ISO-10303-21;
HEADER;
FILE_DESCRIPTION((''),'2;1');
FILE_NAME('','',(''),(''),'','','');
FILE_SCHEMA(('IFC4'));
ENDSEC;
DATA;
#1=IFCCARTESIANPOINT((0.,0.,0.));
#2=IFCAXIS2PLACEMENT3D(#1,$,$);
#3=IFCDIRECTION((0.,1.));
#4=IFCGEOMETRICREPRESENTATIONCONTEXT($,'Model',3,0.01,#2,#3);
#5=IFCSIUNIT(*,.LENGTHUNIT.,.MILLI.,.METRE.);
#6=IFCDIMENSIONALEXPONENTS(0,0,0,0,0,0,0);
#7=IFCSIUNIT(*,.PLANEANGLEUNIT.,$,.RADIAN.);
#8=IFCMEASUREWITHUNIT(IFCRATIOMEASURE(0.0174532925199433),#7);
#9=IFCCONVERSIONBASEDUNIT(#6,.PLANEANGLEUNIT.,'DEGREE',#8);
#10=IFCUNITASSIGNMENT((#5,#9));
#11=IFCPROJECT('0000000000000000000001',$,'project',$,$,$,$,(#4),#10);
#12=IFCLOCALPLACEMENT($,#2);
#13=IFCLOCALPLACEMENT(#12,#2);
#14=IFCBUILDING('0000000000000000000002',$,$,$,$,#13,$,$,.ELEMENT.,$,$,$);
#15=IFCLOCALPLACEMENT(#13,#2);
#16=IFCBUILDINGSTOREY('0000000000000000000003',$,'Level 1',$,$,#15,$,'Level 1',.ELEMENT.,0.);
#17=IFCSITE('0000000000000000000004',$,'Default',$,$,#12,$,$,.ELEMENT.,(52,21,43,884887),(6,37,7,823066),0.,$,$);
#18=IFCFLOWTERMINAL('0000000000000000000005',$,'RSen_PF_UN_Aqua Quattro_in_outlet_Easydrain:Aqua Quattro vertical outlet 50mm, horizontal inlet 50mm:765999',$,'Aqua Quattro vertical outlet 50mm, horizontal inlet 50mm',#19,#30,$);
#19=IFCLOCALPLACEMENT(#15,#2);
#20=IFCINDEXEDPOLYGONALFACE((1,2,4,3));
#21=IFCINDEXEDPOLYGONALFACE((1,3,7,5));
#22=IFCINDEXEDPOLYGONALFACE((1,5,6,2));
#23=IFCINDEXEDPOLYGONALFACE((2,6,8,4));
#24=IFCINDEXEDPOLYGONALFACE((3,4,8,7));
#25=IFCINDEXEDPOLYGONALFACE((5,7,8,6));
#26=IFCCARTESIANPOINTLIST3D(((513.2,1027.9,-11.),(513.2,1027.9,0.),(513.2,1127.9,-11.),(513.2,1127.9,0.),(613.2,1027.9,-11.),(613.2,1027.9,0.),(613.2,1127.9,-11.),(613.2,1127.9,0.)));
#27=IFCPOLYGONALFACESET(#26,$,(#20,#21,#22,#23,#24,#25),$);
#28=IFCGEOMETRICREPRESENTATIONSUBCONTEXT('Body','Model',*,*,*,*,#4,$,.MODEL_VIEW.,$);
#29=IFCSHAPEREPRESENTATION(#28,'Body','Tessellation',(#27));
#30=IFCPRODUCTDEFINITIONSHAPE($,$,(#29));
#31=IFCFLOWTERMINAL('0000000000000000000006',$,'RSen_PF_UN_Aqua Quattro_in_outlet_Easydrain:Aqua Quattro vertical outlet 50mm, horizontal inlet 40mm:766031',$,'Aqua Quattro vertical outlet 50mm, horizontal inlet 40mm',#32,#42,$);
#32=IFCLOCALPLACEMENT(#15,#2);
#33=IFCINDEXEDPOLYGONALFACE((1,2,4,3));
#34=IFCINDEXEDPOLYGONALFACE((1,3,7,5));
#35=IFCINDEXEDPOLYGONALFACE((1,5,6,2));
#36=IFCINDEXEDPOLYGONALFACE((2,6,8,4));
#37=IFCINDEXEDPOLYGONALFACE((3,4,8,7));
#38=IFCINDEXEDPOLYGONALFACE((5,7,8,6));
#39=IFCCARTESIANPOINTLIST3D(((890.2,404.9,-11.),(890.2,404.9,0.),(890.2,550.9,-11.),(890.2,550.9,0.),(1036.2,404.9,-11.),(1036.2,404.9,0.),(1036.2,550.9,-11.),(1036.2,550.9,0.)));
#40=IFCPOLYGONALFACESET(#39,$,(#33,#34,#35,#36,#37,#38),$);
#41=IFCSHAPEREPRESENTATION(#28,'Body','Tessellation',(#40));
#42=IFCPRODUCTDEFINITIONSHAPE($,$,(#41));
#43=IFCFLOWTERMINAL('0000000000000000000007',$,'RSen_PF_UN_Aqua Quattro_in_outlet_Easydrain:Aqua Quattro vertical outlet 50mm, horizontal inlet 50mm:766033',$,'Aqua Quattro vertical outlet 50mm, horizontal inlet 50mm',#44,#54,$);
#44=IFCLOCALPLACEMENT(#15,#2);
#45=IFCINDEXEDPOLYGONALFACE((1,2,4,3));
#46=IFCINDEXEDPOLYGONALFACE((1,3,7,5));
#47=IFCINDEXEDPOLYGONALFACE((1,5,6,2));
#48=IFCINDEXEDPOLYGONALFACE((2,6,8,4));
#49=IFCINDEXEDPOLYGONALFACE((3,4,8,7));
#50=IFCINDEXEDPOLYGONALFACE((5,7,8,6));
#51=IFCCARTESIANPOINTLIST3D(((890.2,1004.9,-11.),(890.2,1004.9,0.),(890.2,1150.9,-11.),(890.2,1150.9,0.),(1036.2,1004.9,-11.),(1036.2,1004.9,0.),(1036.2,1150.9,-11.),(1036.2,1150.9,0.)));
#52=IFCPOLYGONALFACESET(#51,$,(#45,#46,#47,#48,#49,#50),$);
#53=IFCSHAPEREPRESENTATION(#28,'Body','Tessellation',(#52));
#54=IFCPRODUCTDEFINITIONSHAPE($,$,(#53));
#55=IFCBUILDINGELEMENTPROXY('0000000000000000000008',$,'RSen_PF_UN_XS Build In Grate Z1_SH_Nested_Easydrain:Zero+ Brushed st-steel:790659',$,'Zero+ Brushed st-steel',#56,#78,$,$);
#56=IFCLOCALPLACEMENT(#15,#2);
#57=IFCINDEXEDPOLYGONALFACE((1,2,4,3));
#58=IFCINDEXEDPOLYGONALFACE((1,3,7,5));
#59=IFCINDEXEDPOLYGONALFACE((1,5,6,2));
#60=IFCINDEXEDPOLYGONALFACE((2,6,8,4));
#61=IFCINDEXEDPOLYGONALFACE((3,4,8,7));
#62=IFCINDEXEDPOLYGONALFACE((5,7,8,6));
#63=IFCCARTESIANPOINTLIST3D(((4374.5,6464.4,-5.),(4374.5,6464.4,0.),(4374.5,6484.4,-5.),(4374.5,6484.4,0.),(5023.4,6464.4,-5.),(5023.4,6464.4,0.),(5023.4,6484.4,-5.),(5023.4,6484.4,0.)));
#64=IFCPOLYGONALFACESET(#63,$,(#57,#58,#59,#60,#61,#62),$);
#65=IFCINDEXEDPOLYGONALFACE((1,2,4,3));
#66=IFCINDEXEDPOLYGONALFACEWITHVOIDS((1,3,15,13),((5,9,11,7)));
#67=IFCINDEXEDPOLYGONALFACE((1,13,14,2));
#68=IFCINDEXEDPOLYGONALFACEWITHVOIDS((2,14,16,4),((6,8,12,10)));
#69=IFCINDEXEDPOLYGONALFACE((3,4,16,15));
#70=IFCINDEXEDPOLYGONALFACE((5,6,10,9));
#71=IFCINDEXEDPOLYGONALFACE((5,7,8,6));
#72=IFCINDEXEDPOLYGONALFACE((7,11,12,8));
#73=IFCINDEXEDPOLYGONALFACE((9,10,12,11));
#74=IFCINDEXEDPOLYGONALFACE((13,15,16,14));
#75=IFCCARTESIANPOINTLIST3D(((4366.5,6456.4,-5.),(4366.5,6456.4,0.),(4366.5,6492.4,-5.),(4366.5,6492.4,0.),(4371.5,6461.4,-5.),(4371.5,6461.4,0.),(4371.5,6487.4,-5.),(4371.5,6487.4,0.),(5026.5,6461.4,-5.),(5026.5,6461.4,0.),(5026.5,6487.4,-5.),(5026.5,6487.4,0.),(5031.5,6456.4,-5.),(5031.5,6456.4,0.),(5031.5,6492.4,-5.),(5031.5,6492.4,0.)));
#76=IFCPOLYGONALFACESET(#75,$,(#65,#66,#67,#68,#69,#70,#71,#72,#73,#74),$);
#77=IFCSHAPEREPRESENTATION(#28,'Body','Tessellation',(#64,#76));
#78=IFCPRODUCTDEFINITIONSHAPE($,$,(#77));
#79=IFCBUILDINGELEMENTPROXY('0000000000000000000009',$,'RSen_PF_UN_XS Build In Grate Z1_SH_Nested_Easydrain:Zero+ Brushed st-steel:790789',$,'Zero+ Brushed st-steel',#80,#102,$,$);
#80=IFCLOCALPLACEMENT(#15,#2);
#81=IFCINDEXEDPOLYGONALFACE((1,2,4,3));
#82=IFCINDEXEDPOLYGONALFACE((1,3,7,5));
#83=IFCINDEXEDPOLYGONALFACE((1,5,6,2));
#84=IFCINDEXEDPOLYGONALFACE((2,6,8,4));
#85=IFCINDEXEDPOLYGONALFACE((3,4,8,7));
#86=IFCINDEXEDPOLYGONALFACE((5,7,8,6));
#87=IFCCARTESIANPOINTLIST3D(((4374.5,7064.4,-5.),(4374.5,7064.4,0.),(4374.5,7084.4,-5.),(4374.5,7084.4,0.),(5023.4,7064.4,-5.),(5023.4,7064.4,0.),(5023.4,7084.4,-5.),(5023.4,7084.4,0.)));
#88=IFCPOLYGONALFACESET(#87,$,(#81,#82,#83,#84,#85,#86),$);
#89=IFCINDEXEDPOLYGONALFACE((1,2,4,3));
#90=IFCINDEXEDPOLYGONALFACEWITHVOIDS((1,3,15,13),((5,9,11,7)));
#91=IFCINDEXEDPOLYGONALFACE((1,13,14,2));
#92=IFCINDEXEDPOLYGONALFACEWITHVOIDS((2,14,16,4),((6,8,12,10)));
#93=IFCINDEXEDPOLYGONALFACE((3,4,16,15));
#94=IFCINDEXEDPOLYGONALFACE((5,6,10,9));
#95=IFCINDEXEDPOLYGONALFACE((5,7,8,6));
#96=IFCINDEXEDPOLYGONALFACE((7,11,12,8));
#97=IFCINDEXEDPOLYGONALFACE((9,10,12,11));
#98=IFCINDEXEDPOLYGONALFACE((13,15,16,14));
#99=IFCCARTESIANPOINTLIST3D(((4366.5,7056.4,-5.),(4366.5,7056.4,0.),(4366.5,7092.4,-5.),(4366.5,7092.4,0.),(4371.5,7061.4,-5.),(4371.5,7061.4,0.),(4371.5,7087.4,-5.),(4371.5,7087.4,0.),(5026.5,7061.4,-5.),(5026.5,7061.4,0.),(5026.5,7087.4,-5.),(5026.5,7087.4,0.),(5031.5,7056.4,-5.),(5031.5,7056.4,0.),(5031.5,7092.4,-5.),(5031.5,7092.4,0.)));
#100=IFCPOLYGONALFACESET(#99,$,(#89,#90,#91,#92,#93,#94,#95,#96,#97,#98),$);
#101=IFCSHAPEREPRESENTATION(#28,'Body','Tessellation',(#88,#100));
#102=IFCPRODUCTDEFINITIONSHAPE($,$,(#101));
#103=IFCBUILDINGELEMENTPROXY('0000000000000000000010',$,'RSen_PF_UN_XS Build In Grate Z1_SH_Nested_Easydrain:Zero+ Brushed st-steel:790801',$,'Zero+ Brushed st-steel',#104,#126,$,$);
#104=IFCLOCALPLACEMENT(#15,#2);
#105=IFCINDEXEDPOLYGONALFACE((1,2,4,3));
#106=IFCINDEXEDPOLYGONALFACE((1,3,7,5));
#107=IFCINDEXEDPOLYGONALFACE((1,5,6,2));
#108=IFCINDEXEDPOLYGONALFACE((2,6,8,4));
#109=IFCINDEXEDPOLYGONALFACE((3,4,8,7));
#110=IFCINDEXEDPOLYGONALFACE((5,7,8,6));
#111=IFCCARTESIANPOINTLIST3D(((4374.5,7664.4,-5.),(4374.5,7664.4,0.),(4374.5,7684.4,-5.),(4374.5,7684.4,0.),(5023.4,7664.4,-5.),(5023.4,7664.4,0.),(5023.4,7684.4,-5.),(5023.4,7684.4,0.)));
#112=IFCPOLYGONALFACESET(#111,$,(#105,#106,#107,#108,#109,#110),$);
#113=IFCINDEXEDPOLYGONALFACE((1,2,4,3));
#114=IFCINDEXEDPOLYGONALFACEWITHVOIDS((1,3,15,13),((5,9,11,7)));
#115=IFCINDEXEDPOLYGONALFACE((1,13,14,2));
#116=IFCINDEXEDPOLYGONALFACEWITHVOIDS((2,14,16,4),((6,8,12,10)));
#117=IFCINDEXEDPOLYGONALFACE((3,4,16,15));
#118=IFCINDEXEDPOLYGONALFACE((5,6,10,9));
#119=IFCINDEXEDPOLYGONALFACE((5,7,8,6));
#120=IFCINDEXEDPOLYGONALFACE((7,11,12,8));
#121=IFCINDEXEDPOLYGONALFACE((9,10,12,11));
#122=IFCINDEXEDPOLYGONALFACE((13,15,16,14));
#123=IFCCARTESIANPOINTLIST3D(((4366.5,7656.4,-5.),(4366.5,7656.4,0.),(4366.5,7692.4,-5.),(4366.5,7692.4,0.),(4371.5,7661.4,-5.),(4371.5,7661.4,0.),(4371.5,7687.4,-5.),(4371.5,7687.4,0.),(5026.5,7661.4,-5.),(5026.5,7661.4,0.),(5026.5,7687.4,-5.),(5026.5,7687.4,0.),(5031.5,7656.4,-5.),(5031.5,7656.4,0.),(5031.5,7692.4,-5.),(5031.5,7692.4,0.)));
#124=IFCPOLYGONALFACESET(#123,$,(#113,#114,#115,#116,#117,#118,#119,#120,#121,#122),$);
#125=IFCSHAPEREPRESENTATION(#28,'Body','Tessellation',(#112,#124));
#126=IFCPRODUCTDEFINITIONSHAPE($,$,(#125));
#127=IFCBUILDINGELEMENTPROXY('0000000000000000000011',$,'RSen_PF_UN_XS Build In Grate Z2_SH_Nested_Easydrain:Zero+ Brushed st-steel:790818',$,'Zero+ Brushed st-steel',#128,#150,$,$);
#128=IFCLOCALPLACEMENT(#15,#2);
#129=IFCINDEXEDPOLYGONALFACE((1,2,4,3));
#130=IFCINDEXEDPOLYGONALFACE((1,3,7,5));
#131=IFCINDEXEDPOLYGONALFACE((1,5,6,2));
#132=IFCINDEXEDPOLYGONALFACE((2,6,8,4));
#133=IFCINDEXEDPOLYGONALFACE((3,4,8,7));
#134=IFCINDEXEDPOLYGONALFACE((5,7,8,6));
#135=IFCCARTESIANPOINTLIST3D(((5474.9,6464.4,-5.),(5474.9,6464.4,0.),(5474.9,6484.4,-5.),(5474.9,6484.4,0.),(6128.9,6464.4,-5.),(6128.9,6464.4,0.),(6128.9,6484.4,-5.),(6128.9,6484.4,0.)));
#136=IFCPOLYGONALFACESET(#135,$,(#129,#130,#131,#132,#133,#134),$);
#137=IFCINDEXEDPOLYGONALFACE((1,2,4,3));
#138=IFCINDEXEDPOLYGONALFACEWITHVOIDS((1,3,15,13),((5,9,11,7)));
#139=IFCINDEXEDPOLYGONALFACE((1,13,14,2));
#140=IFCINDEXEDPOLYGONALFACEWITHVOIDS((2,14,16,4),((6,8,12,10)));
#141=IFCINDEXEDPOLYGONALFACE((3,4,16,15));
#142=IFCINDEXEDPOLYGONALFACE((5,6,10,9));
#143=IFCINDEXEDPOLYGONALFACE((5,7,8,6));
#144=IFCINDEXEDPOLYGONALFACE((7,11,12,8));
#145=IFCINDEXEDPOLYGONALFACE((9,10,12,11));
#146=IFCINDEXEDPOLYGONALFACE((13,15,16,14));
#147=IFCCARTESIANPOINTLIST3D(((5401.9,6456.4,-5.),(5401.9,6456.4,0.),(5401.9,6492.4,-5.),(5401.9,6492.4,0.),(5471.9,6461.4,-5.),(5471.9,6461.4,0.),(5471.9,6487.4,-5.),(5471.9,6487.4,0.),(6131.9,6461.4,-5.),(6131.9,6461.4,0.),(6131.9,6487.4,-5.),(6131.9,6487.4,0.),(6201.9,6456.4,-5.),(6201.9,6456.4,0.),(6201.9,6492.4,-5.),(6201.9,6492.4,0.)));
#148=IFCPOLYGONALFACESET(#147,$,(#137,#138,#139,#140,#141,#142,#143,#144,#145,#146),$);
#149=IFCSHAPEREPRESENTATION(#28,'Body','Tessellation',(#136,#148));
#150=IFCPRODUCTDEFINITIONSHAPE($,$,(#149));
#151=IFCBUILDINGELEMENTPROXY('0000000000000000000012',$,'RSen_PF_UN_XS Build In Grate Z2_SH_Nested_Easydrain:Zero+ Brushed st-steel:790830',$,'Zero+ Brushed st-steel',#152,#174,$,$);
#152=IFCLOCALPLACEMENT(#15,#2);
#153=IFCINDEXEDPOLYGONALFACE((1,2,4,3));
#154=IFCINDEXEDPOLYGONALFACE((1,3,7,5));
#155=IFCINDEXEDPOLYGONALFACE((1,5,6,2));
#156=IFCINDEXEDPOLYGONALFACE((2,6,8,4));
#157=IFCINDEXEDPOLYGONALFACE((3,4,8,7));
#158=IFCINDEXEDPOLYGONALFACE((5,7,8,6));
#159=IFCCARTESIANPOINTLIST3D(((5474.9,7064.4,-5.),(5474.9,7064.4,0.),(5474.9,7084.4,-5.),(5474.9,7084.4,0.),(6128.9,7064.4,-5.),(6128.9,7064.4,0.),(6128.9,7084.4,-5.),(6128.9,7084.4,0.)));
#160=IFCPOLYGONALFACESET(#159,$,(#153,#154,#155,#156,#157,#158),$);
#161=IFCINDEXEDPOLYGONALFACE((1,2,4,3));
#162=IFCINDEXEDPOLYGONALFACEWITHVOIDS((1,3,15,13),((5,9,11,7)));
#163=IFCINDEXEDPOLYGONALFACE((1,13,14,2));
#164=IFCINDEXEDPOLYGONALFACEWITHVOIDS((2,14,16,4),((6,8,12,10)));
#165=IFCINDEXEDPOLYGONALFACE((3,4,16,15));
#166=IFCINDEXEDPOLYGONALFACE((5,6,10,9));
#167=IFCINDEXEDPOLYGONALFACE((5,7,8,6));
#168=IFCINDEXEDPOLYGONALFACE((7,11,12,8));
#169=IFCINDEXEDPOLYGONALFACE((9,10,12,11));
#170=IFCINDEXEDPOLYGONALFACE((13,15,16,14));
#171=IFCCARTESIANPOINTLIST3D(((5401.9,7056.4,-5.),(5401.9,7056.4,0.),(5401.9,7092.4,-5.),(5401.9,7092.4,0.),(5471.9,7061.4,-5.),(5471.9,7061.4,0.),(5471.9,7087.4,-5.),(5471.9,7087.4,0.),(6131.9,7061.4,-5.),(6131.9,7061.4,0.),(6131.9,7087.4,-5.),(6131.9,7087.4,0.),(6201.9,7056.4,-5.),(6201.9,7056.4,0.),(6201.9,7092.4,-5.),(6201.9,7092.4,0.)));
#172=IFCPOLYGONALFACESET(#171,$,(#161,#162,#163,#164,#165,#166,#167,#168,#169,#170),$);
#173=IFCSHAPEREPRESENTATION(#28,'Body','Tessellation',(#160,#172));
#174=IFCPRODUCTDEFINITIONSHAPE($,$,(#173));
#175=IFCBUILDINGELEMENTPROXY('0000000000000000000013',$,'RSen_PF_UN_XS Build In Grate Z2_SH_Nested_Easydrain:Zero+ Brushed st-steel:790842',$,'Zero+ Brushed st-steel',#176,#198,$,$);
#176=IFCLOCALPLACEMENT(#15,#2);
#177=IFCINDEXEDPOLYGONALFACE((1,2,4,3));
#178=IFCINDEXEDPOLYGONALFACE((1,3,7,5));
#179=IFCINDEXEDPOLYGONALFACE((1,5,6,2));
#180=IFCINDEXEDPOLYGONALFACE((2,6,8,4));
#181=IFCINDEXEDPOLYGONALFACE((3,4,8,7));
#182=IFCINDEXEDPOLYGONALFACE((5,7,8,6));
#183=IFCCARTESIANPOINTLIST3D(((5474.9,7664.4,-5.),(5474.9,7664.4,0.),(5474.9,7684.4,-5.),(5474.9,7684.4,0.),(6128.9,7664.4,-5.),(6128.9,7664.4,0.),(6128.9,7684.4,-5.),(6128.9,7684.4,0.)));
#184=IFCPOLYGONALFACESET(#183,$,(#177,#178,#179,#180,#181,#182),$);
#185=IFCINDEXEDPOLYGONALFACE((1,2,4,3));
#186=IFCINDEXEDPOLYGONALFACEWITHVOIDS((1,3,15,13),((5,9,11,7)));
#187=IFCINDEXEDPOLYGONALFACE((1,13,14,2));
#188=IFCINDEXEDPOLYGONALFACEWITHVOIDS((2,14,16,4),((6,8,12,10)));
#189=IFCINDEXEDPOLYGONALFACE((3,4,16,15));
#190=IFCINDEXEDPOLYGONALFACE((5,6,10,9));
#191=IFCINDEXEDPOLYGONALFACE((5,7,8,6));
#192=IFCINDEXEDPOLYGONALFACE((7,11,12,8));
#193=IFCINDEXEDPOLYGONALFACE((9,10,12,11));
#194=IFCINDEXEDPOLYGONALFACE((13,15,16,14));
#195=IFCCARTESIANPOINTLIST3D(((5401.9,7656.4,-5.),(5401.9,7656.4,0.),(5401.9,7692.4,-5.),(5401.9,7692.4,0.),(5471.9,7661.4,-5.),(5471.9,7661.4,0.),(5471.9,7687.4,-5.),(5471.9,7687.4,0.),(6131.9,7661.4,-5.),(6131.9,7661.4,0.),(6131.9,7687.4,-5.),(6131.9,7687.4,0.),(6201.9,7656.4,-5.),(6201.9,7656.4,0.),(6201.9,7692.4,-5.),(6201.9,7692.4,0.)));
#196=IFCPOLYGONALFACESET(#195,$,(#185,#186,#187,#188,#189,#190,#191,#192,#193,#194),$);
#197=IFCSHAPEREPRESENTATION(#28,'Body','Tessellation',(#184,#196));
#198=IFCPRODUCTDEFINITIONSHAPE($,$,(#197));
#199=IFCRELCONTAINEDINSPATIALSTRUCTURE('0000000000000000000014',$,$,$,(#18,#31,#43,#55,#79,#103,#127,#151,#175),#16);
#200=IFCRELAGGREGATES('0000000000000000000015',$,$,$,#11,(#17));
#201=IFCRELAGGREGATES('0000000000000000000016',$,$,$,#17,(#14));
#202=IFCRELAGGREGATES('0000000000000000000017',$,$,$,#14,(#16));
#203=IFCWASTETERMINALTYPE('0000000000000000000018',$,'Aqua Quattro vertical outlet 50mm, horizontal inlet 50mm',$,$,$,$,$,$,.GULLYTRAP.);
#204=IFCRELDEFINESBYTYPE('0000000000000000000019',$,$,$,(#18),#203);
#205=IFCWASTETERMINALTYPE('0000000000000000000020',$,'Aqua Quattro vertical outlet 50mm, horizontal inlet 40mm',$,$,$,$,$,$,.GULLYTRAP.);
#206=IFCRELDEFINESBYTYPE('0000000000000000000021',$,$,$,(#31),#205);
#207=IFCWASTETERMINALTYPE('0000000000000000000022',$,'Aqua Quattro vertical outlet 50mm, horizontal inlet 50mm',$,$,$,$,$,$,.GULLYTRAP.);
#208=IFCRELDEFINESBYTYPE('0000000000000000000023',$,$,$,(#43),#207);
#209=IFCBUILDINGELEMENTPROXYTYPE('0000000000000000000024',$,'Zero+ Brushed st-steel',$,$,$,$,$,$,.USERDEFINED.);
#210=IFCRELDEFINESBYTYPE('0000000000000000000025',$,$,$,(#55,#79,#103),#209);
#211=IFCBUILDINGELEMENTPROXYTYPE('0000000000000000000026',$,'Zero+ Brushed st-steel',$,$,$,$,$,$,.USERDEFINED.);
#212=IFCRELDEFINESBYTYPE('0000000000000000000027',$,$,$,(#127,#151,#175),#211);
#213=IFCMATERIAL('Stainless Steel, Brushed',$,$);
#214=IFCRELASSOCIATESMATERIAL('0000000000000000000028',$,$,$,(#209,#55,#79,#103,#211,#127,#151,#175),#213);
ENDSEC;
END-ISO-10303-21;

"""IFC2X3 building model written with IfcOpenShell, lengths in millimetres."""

from ifc_helpers import new_model, entity, si_unit, converted_unit, direction, frame, origin, origin_2d_with_axis, place, context, subcontext, project, spatial, polyline, rectangle, outline, extrude, source, transform, mapped, material, type_object, type_shapes, element, save


model = new_model("IFC2X3")

# Units and contexts
model_context = context("Model", 3, precision=0.01, world=origin(), true_north=direction((0.0, 1.0)))
body_context = subcontext(model_context, "Body", "Model", "MODEL_VIEW")
ifc_project = project(units=[si_unit("LENGTHUNIT", "METRE", prefix="MILLI"), converted_unit("PLANEANGLEUNIT", "DEGREE", entity("IfcRatioMeasure", 0.0174532925199433), si_unit("PLANEANGLEUNIT", "RADIAN"), dimensions=[0, 0, 0, 0, 0, 0, 0])], contexts=[model_context])

# Site, building, storey
site_placement = place(None, origin())
site = spatial("IfcSite", under=ifc_project, at=site_placement, Name="Default", CompositionType="ELEMENT", RefLatitude=(52, 21, 43, 884887), RefLongitude=(6, 37, 7, 823066), RefElevation=0.0)
building_placement = place(site_placement, origin())
building = spatial("IfcBuilding", under=site, at=building_placement, CompositionType="ELEMENT")
storey_placement = place(building_placement, origin())
storey = spatial("IfcBuildingStorey", under=building, at=storey_placement, Name="Level 1", LongName="Level 1", CompositionType="ELEMENT", Elevation=0.0)

# Flow terminals
waste_terminal_type_1 = type_object("IfcWasteTerminalType", Name="Aqua Quattro vertical outlet 50mm, horizontal inlet 50mm", PredefinedType="GULLYTRAP")
shared_shape_1 = source(origin(), body_context, "Body", "SweptSolid", [
    extrude(rectangle(XDim=100.0, YDim=100.0, at=origin_2d_with_axis()), frame((0.0, 0.0, -11.0), z_axis=(0.0, 0.0, 1.0), x_axis=(-1.0, 0.0, 0.0)), (0.0, 0.0, 1.0), 11.0),
])
type_shapes(waste_terminal_type_1, [shared_shape_1])
flow_terminal_1_placement = place(storey_placement, frame((563.2, 1077.9, 0.0)))
element("IfcFlowTerminal", 1, at=flow_terminal_1_placement, inside=storey, type_object=waste_terminal_type_1, Name="RSen_PF_UN_Aqua Quattro_in_outlet_Easydrain:Aqua Quattro vertical outlet 50mm, horizontal inlet 50mm:765999", ObjectType="Aqua Quattro vertical outlet 50mm, horizontal inlet 50mm", context=body_context, shape_type="MappedRepresentation", body=[
    mapped(shared_shape_1, transform((0.0, 0.0, 0.0), scale=1.0)),
])
waste_terminal_type_2 = type_object("IfcWasteTerminalType", Name="Aqua Quattro vertical outlet 50mm, horizontal inlet 40mm", PredefinedType="GULLYTRAP")
shared_shape_2 = source(origin(), body_context, "Body", "SweptSolid", [
    extrude(rectangle(XDim=146.0, YDim=146.0, at=origin_2d_with_axis()), frame((0.0, 0.0, -11.0), z_axis=(0.0, 0.0, 1.0), x_axis=(-1.0, 0.0, 0.0)), (0.0, 0.0, 1.0), 11.0),
])
type_shapes(waste_terminal_type_2, [shared_shape_2])
flow_terminal_2_placement = place(storey_placement, frame((963.2, 477.9, 0.0)))
element("IfcFlowTerminal", 2, at=flow_terminal_2_placement, inside=storey, type_object=waste_terminal_type_2, Name="RSen_PF_UN_Aqua Quattro_in_outlet_Easydrain:Aqua Quattro vertical outlet 50mm, horizontal inlet 40mm:766031", ObjectType="Aqua Quattro vertical outlet 50mm, horizontal inlet 40mm", context=body_context, shape_type="MappedRepresentation", body=[
    mapped(shared_shape_2, transform((0.0, 0.0, 0.0), scale=1.0)),
])
waste_terminal_type_3 = type_object("IfcWasteTerminalType", Name="Aqua Quattro vertical outlet 50mm, horizontal inlet 50mm", PredefinedType="GULLYTRAP")
shared_shape_3 = source(origin(), body_context, "Body", "SweptSolid", [
    extrude(rectangle(XDim=146.0, YDim=146.0, at=origin_2d_with_axis()), frame((0.0, 0.0, -11.0), z_axis=(0.0, 0.0, 1.0), x_axis=(-1.0, 0.0, 0.0)), (0.0, 0.0, 1.0), 11.0),
])
type_shapes(waste_terminal_type_3, [shared_shape_3])
flow_terminal_3_placement = place(storey_placement, frame((963.2, 1077.9, 0.0)))
element("IfcFlowTerminal", 3, at=flow_terminal_3_placement, inside=storey, type_object=waste_terminal_type_3, Name="RSen_PF_UN_Aqua Quattro_in_outlet_Easydrain:Aqua Quattro vertical outlet 50mm, horizontal inlet 50mm:766033", ObjectType="Aqua Quattro vertical outlet 50mm, horizontal inlet 50mm", context=body_context, shape_type="MappedRepresentation", body=[
    mapped(shared_shape_3, transform((0.0, 0.0, 0.0), scale=1.0)),
])

# Building element proxies
ifc_material_1 = material(Name="Stainless Steel, Brushed")
building_element_proxy_type_1 = type_object("IfcBuildingElementProxyType", Name="Zero+ Brushed st-steel", PredefinedType="USERDEFINED", material=ifc_material_1)
shared_shape_4 = source(origin(), body_context, "Body", "SweptSolid", [
    extrude(rectangle(XDim=649.0, YDim=20.0, at=origin_2d_with_axis()), frame((0.0, 0.0, 0.0), z_axis=(0.0, 0.0, 1.0), x_axis=(-1.0, 0.0, 0.0)), (0.0, 0.0, 1.0), 5.0),
    extrude(outline(polyline([(-332.5, -18.0), (332.5, -18.0), (332.5, 18.0), (-332.5, 18.0), (-332.5, -18.0)]), holes=[polyline([(-327.5, -13.0), (-327.5, 13.0), (327.5, 13.0), (327.5, -13.0), (-327.5, -13.0)])]), frame((0.0, 0.0, 0.0), z_axis=(0.0, 0.0, 1.0), x_axis=(-1.0, 0.0, 0.0)), (0.0, 0.0, 1.0), 5.0),
])
type_shapes(building_element_proxy_type_1, [shared_shape_4])
for number, where, name in (
    (4, (4699.0, 6474.4, -5.0), "RSen_PF_UN_XS Build In Grate Z1_SH_Nested_Easydrain:Zero+ Brushed st-steel:790659"),
    (5, (4699.0, 7074.4, -5.0), "RSen_PF_UN_XS Build In Grate Z1_SH_Nested_Easydrain:Zero+ Brushed st-steel:790789"),
    (6, (4699.0, 7674.4, -5.0), "RSen_PF_UN_XS Build In Grate Z1_SH_Nested_Easydrain:Zero+ Brushed st-steel:790801"),
):
    element("IfcBuildingElementProxy", number, at=place(storey_placement, frame(where)), inside=storey, type_object=building_element_proxy_type_1, material=ifc_material_1, Name=name, ObjectType="Zero+ Brushed st-steel", context=body_context, shape_type="MappedRepresentation", body=[
        mapped(shared_shape_4, transform((0.0, 0.0, 0.0), scale=1.0)),
    ])
building_element_proxy_type_2 = type_object("IfcBuildingElementProxyType", Name="Zero+ Brushed st-steel", PredefinedType="USERDEFINED", material=ifc_material_1)
shared_shape_5 = source(origin(), body_context, "Body", "SweptSolid", [
    extrude(rectangle(XDim=654.0, YDim=20.0, at=origin_2d_with_axis()), frame((0.0, 0.0, 0.0), z_axis=(0.0, 0.0, 1.0), x_axis=(-1.0, 0.0, 0.0)), (0.0, 0.0, 1.0), 5.0),
    extrude(outline(polyline([(-400.0, -18.0), (400.0, -18.0), (400.0, 18.0), (-400.0, 18.0), (-400.0, -18.0)]), holes=[polyline([(-330.0, -13.0), (-330.0, 13.0), (330.0, 13.0), (330.0, -13.0), (-330.0, -13.0)])]), frame((0.0, 0.0, 0.0), z_axis=(0.0, 0.0, 1.0), x_axis=(-1.0, 0.0, 0.0)), (0.0, 0.0, 1.0), 5.0),
])
type_shapes(building_element_proxy_type_2, [shared_shape_5])
for number, where, name in (
    (7, (5801.9, 6474.4, -5.0), "RSen_PF_UN_XS Build In Grate Z2_SH_Nested_Easydrain:Zero+ Brushed st-steel:790818"),
    (8, (5801.9, 7074.4, -5.0), "RSen_PF_UN_XS Build In Grate Z2_SH_Nested_Easydrain:Zero+ Brushed st-steel:790830"),
    (9, (5801.9, 7674.4, -5.0), "RSen_PF_UN_XS Build In Grate Z2_SH_Nested_Easydrain:Zero+ Brushed st-steel:790842"),
):
    element("IfcBuildingElementProxy", number, at=place(storey_placement, frame(where)), inside=storey, type_object=building_element_proxy_type_2, material=ifc_material_1, Name=name, ObjectType="Zero+ Brushed st-steel", context=body_context, shape_type="MappedRepresentation", body=[
        mapped(shared_shape_5, transform((0.0, 0.0, 0.0), scale=1.0)),
    ])

save(model, "model.ifc")
